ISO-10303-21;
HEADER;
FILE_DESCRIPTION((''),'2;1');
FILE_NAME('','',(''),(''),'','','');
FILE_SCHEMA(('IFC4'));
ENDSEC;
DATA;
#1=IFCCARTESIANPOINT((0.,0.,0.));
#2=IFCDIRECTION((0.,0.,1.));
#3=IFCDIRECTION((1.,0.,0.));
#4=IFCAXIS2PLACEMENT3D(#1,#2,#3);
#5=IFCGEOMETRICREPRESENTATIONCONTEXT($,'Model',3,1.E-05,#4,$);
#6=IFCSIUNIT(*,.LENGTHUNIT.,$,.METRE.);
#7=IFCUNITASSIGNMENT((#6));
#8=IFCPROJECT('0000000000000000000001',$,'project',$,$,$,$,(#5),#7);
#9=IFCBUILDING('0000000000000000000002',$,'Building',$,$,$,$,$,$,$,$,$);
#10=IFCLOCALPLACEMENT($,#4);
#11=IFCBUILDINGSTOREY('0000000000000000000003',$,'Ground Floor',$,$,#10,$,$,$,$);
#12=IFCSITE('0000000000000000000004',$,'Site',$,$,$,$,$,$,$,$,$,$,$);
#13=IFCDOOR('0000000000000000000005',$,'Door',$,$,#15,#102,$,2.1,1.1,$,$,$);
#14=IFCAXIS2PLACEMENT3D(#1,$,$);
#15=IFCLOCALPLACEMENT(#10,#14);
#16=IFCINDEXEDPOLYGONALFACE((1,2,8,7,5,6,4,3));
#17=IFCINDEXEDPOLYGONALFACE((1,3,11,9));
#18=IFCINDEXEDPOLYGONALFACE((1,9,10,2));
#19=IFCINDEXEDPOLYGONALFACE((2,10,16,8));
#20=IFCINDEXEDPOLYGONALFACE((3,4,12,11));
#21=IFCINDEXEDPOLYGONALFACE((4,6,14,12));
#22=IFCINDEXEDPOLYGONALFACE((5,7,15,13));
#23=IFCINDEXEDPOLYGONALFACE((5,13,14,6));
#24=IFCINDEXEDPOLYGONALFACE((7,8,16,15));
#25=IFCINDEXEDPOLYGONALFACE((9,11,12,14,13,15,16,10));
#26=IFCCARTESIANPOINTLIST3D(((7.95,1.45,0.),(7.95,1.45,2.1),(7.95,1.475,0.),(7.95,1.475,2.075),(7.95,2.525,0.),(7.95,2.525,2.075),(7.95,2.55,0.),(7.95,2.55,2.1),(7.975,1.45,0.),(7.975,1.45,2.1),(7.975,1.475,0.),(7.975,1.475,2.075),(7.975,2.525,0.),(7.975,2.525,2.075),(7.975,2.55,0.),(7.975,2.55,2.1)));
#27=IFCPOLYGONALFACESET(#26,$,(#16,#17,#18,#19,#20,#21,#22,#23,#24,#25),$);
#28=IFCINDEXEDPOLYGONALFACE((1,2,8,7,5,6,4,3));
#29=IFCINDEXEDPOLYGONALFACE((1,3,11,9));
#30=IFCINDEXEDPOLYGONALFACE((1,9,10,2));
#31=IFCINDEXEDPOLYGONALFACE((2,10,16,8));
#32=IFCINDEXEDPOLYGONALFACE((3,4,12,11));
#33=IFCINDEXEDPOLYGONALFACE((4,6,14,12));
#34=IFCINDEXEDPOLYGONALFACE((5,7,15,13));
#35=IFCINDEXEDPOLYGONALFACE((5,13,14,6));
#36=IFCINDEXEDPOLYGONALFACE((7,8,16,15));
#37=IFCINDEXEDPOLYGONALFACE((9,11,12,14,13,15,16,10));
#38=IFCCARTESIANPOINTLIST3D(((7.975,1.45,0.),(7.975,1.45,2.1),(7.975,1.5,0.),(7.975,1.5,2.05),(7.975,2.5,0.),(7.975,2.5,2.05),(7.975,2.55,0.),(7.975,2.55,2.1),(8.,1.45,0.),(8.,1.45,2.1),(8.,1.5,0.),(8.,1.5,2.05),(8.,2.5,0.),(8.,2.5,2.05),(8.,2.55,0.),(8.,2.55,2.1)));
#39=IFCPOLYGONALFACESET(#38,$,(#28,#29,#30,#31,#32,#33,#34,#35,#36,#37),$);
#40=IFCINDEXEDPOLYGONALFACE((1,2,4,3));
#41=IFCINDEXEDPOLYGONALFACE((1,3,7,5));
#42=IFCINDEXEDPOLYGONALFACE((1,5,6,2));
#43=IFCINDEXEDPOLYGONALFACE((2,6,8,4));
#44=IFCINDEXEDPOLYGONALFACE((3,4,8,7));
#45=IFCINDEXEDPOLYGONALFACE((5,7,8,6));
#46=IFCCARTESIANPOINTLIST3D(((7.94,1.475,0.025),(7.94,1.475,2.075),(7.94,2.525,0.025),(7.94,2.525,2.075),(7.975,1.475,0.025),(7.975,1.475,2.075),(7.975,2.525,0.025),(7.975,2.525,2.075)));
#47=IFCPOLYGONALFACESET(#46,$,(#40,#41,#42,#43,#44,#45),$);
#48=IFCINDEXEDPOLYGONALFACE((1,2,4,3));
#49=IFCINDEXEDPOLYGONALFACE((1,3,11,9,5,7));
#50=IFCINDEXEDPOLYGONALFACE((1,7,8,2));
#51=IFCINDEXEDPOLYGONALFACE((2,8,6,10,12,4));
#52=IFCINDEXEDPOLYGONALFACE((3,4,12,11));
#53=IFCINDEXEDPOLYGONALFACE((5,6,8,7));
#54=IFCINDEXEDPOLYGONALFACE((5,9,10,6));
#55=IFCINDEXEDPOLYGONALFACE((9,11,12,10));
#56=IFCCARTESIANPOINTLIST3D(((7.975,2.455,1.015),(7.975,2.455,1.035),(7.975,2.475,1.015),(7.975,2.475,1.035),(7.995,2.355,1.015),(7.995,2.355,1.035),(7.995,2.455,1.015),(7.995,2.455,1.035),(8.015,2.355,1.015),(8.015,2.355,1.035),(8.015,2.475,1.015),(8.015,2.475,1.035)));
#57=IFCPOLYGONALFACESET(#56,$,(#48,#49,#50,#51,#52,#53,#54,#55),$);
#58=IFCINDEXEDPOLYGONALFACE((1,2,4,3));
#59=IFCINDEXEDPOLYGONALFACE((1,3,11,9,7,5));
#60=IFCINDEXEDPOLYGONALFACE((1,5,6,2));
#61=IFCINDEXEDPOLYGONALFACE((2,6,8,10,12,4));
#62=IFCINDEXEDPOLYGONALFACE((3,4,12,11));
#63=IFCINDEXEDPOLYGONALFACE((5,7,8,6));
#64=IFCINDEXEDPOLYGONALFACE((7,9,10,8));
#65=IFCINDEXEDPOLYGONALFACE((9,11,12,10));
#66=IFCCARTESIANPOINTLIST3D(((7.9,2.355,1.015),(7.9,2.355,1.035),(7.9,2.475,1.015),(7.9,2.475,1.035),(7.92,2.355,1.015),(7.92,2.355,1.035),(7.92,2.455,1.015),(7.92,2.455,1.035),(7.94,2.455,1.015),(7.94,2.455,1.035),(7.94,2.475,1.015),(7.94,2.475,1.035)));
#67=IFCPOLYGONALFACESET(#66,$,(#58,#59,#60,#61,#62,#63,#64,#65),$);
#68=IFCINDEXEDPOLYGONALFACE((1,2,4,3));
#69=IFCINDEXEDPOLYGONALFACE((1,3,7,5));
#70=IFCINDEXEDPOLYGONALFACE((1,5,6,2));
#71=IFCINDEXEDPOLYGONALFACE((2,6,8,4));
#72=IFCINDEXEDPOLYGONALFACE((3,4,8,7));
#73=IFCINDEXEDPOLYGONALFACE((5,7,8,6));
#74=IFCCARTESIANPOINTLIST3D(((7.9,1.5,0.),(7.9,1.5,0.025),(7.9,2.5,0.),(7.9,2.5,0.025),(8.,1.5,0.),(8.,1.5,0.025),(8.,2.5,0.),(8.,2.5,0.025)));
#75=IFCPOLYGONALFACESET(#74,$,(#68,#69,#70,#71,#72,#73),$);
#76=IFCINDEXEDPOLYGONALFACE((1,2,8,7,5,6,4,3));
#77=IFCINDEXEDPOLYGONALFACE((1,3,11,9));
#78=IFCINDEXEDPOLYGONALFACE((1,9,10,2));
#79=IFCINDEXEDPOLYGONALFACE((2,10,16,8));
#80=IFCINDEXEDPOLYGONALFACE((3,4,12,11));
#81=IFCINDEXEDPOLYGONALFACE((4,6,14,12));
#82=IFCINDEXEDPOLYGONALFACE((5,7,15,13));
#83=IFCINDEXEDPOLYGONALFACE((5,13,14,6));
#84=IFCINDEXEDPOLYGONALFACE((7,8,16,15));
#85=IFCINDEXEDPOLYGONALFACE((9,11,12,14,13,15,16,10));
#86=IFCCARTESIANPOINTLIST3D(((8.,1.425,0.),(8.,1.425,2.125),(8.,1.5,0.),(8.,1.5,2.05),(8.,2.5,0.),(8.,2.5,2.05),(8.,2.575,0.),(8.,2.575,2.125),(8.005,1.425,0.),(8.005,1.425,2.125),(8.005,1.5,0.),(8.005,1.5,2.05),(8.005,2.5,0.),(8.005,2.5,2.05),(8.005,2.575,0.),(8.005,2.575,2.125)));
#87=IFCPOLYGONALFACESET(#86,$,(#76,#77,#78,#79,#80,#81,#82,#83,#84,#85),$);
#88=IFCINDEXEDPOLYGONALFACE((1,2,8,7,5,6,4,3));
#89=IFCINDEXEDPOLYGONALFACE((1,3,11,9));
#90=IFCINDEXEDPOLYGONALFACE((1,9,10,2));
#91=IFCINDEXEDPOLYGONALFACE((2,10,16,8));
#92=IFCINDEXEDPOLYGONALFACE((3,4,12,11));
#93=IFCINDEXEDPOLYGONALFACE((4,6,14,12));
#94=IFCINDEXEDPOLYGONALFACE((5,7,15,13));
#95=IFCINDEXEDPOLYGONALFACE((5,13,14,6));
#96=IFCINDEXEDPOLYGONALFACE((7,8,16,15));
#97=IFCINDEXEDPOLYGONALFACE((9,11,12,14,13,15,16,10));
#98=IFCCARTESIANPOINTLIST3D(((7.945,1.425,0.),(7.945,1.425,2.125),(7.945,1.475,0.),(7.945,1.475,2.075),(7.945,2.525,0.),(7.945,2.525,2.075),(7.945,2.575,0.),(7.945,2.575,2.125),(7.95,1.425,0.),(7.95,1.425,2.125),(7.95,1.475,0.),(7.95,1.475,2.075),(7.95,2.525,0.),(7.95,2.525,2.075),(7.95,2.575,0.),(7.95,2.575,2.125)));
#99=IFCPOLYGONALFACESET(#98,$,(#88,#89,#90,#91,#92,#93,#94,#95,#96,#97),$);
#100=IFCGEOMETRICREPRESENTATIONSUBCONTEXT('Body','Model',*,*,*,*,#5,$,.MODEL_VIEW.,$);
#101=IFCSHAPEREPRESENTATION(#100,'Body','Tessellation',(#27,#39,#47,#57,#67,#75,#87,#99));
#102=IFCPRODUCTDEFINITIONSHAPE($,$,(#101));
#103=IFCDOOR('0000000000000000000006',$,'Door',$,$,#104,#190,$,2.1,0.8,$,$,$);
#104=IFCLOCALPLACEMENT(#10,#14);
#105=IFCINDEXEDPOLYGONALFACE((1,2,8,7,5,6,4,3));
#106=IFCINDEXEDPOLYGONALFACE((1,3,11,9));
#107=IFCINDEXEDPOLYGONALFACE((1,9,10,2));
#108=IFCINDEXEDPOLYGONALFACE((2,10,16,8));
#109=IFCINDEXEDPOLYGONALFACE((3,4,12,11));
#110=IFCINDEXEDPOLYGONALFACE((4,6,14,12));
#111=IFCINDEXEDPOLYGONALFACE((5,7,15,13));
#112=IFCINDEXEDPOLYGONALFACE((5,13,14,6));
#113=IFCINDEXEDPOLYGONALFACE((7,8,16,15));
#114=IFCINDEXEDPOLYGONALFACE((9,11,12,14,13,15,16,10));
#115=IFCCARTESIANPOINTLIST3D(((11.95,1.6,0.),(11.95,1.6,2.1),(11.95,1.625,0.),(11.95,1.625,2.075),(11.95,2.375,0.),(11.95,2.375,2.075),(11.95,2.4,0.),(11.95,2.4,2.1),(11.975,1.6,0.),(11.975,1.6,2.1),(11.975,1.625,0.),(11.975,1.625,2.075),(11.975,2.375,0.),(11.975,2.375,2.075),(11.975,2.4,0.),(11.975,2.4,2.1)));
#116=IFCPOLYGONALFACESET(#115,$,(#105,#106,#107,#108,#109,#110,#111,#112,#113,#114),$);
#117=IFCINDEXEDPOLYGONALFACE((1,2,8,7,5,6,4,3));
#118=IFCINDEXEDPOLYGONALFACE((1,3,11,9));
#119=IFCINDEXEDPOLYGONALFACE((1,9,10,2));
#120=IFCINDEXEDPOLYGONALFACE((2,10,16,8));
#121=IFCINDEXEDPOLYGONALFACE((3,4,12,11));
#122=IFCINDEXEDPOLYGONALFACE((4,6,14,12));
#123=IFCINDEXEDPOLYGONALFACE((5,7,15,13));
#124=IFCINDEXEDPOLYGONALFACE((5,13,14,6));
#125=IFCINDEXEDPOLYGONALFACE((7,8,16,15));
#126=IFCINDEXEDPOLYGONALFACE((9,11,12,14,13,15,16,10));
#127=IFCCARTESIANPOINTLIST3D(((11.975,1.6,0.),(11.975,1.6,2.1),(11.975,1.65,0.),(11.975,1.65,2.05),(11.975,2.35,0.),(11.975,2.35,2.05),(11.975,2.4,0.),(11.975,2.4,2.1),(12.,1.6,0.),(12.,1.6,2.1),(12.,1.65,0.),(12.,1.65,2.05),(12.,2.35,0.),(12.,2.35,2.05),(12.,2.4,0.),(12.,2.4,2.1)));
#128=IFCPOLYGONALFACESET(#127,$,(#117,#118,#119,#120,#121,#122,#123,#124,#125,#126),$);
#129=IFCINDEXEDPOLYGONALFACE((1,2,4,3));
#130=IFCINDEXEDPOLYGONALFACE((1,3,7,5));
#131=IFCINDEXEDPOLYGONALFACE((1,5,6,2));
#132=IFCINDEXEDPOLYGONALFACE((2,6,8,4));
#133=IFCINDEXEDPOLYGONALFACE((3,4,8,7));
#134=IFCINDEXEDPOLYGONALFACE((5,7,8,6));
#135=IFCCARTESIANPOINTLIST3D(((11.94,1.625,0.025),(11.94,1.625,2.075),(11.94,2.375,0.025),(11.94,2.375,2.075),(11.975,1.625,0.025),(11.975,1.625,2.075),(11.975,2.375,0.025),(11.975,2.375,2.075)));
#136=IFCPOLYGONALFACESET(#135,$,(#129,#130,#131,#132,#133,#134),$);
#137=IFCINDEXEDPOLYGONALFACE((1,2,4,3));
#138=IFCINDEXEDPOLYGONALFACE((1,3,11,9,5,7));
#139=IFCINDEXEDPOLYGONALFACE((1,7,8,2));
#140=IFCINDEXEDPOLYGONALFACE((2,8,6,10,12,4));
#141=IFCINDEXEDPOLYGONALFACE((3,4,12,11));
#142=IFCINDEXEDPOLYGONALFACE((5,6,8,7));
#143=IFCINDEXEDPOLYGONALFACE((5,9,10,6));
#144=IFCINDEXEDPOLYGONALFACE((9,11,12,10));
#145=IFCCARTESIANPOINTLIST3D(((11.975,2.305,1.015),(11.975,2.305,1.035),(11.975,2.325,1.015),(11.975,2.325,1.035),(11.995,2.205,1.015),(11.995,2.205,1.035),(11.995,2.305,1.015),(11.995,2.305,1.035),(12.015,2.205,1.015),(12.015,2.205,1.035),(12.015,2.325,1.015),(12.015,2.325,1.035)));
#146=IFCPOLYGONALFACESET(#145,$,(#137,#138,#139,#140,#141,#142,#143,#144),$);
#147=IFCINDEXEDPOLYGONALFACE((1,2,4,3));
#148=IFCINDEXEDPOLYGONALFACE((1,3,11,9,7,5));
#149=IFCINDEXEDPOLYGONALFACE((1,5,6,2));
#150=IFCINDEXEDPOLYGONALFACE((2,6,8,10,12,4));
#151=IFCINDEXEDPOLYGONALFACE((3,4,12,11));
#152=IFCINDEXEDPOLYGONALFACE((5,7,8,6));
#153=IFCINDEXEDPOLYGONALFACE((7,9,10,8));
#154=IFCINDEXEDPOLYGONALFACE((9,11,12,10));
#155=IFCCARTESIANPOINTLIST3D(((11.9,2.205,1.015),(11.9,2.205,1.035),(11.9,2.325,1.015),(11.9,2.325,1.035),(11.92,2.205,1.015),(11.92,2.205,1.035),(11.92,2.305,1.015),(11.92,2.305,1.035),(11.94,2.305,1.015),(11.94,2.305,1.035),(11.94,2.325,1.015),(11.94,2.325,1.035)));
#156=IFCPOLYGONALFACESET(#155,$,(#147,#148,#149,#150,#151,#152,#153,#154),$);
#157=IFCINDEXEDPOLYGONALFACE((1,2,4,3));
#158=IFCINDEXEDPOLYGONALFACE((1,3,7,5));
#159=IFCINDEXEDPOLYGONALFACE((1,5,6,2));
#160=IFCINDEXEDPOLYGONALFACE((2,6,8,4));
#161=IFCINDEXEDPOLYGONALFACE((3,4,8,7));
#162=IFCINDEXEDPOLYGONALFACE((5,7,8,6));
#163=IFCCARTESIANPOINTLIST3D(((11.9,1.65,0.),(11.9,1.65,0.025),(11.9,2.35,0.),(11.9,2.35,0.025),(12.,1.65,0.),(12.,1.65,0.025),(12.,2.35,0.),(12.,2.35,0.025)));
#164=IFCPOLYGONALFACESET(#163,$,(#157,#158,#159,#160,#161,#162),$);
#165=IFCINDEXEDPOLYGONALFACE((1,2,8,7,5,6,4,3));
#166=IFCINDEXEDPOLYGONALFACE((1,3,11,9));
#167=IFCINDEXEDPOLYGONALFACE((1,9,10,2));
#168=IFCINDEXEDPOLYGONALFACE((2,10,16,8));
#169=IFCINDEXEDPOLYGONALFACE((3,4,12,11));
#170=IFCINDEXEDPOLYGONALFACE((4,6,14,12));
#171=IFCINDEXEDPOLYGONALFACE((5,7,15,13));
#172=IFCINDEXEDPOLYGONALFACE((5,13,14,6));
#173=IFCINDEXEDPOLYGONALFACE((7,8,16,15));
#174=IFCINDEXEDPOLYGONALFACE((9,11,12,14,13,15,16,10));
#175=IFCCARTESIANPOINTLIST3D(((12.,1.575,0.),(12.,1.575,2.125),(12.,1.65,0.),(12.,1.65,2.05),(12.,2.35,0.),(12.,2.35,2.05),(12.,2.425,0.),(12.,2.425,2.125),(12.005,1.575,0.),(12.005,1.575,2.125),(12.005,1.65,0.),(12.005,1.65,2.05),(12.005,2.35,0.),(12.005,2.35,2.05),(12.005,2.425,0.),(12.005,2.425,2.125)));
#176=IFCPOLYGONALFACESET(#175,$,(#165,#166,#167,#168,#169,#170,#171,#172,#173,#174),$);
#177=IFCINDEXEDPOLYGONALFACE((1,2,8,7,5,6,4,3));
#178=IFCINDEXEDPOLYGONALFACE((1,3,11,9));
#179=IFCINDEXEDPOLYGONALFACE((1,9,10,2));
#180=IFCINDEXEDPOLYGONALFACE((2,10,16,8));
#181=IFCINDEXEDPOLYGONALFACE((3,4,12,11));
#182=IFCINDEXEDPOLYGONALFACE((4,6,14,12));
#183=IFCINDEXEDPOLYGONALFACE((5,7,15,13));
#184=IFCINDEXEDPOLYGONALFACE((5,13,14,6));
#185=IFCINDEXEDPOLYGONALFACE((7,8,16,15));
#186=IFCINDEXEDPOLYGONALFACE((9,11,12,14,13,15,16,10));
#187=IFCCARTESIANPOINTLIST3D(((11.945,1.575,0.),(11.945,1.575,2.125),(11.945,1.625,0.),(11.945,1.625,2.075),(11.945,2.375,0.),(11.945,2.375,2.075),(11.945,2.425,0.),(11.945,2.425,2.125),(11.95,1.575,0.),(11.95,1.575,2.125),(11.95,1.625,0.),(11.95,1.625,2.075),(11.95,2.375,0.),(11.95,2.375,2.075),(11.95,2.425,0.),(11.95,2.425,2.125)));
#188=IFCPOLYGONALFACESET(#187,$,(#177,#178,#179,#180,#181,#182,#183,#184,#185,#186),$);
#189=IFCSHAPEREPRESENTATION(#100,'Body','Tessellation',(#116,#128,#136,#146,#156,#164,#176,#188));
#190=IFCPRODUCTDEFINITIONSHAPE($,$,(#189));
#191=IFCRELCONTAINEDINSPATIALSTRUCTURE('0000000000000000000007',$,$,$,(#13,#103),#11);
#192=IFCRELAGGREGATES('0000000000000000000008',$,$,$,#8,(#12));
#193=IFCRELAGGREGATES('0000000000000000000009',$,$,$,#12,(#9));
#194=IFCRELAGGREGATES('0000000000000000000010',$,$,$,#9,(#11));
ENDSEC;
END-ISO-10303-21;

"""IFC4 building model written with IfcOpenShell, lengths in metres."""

from ifc_helpers import new_model, si_unit, frame, origin_with_axes, place, context, subcontext, project, spatial, line, indexed_curve, outline, extrude, element, save


model = new_model("IFC4")

# Units and contexts
model_context = context("Model", 3, precision=1e-05, world=origin_with_axes())
body_context = subcontext(model_context, "Body", "Model", "MODEL_VIEW")
ifc_project = project(units=[si_unit("LENGTHUNIT", "METRE")], contexts=[model_context])

# Site, building, storey
site = spatial("IfcSite", under=ifc_project, Name="Site")
building = spatial("IfcBuilding", under=site, Name="Building")
storey_placement = place(None, origin_with_axes())
storey = spatial("IfcBuildingStorey", under=building, at=storey_placement, Name="Ground Floor")

# Doors
door_1_placement = place(storey_placement, frame((8.0, 1.45, 0.0), z_axis=(0.0, 0.0, 1.0), x_axis=(0.0, 1.0, 0.0)))
element("IfcDoor", 1, at=door_1_placement, inside=storey, Name="Door", OverallHeight=2.1, OverallWidth=1.1, context=body_context, shape_type="SweptSolid", body=[
    extrude(outline(indexed_curve([(0.0, 0.0), (0.0, 2.1), (1.1, 2.1), (1.1, 0.0), (1.075, 0.0), (1.075, 2.075), (0.025, 2.075), (0.025, 0.0)], segments=[line(1, 2, 3, 4, 5, 6, 7, 8, 1)])), frame((0.0, 0.025, 0.0), z_axis=(0.0, -1.0, 0.0), x_axis=(1.0, 0.0, 0.0)), (0.0, 0.0, -1.0), 0.025),
    extrude(outline(indexed_curve([(0.0, 0.0), (0.0, 2.1), (1.1, 2.1), (1.1, 0.0), (1.05, 0.0), (1.05, 2.05), (0.05, 2.05), (0.05, 0.0)], segments=[line(1, 2, 3, 4, 5, 6, 7, 8, 1)])), frame((0.0, 0.0, 0.0), z_axis=(0.0, -1.0, 0.0), x_axis=(1.0, 0.0, 0.0)), (0.0, 0.0, -1.0), 0.025),
    extrude(outline(indexed_curve([(0.0, 0.0), (1.05, 0.0), (1.05, 0.035), (0.0, 0.035)], segments=[line(1, 2, 3, 4, 1)])), frame((0.025, 0.025, 0.025), z_axis=(0.0, 0.0, 1.0), x_axis=(1.0, 0.0, 0.0)), (0.0, 0.0, 1.0), 2.05),
    extrude(outline(indexed_curve([(0.0, 0.0), (0.0, -0.04), (-0.12, -0.04), (-0.12, -0.02), (-0.02, -0.02), (-0.02, 0.0)], segments=[line(1, 2, 3, 4, 5, 6, 1)])), frame((1.025, 0.025, 1.015), z_axis=(0.0, 0.0, 1.0), x_axis=(1.0, 0.0, 0.0)), (0.0, 0.0, 1.0), 0.02),
    extrude(outline(indexed_curve([(0.0, 0.0), (0.0, 0.04), (-0.12, 0.04), (-0.12, 0.02), (-0.02, 0.02), (-0.02, 0.0)], segments=[line(1, 2, 3, 4, 5, 6, 1)])), frame((1.025, 0.06, 1.015), z_axis=(0.0, 0.0, 1.0), x_axis=(1.0, 0.0, 0.0)), (0.0, 0.0, 1.0), 0.02),
    extrude(outline(indexed_curve([(0.0, 0.0), (1.0, 0.0), (1.0, 0.1), (0.0, 0.1)], segments=[line(1, 2, 3, 4, 1)])), frame((0.05, 0.0, 0.0), z_axis=(0.0, 0.0, 1.0), x_axis=(1.0, 0.0, 0.0)), (0.0, 0.0, 1.0), 0.025),
    extrude(outline(indexed_curve([(0.0, 0.0), (0.0, 2.125), (1.15, 2.125), (1.15, 0.0), (1.075, 0.0), (1.075, 2.05), (0.075, 2.05), (0.075, 0.0)], segments=[line(1, 2, 3, 4, 5, 6, 7, 8, 1)])), frame((-0.025, -0.005, 0.0), z_axis=(0.0, -1.0, 0.0), x_axis=(1.0, 0.0, 0.0)), (0.0, 0.0, -1.0), 0.005),
    extrude(outline(indexed_curve([(0.0, 0.0), (0.0, 2.125), (1.15, 2.125), (1.15, 0.0), (1.1, 0.0), (1.1, 2.075), (0.05, 2.075), (0.05, 0.0)], segments=[line(1, 2, 3, 4, 5, 6, 7, 8, 1)])), frame((-0.025, 0.05, 0.0), z_axis=(0.0, -1.0, 0.0), x_axis=(1.0, 0.0, 0.0)), (0.0, 0.0, -1.0), 0.005),
])
door_2_placement = place(storey_placement, frame((12.0, 1.6, 0.0), z_axis=(0.0, 0.0, 1.0), x_axis=(0.0, 1.0, 0.0)))
element("IfcDoor", 2, at=door_2_placement, inside=storey, Name="Door", OverallHeight=2.1, OverallWidth=0.8, context=body_context, shape_type="SweptSolid", body=[
    extrude(outline(indexed_curve([(0.0, 0.0), (0.0, 2.1), (0.8, 2.1), (0.8, 0.0), (0.775, 0.0), (0.775, 2.075), (0.025, 2.075), (0.025, 0.0)], segments=[line(1, 2, 3, 4, 5, 6, 7, 8, 1)])), frame((0.0, 0.025, 0.0), z_axis=(0.0, -1.0, 0.0), x_axis=(1.0, 0.0, 0.0)), (0.0, 0.0, -1.0), 0.025),
    extrude(outline(indexed_curve([(0.0, 0.0), (0.0, 2.1), (0.8, 2.1), (0.8, 0.0), (0.75, 0.0), (0.75, 2.05), (0.05, 2.05), (0.05, 0.0)], segments=[line(1, 2, 3, 4, 5, 6, 7, 8, 1)])), frame((0.0, 0.0, 0.0), z_axis=(0.0, -1.0, 0.0), x_axis=(1.0, 0.0, 0.0)), (0.0, 0.0, -1.0), 0.025),
    extrude(outline(indexed_curve([(0.0, 0.0), (0.75, 0.0), (0.75, 0.035), (0.0, 0.035)], segments=[line(1, 2, 3, 4, 1)])), frame((0.025, 0.025, 0.025), z_axis=(0.0, 0.0, 1.0), x_axis=(1.0, 0.0, 0.0)), (0.0, 0.0, 1.0), 2.05),
    extrude(outline(indexed_curve([(0.0, 0.0), (0.0, -0.04), (-0.12, -0.04), (-0.12, -0.02), (-0.02, -0.02), (-0.02, 0.0)], segments=[line(1, 2, 3, 4, 5, 6, 1)])), frame((0.725, 0.025, 1.015), z_axis=(0.0, 0.0, 1.0), x_axis=(1.0, 0.0, 0.0)), (0.0, 0.0, 1.0), 0.02),
    extrude(outline(indexed_curve([(0.0, 0.0), (0.0, 0.04), (-0.12, 0.04), (-0.12, 0.02), (-0.02, 0.02), (-0.02, 0.0)], segments=[line(1, 2, 3, 4, 5, 6, 1)])), frame((0.725, 0.06, 1.015), z_axis=(0.0, 0.0, 1.0), x_axis=(1.0, 0.0, 0.0)), (0.0, 0.0, 1.0), 0.02),
    extrude(outline(indexed_curve([(0.0, 0.0), (0.7, 0.0), (0.7, 0.1), (0.0, 0.1)], segments=[line(1, 2, 3, 4, 1)])), frame((0.05, 0.0, 0.0), z_axis=(0.0, 0.0, 1.0), x_axis=(1.0, 0.0, 0.0)), (0.0, 0.0, 1.0), 0.025),
    extrude(outline(indexed_curve([(0.0, 0.0), (0.0, 2.125), (0.85, 2.125), (0.85, 0.0), (0.775, 0.0), (0.775, 2.05), (0.075, 2.05), (0.075, 0.0)], segments=[line(1, 2, 3, 4, 5, 6, 7, 8, 1)])), frame((-0.025, -0.005, 0.0), z_axis=(0.0, -1.0, 0.0), x_axis=(1.0, 0.0, 0.0)), (0.0, 0.0, -1.0), 0.005),
    extrude(outline(indexed_curve([(0.0, 0.0), (0.0, 2.125), (0.85, 2.125), (0.85, 0.0), (0.8, 0.0), (0.8, 2.075), (0.05, 2.075), (0.05, 0.0)], segments=[line(1, 2, 3, 4, 5, 6, 7, 8, 1)])), frame((-0.025, 0.05, 0.0), z_axis=(0.0, -1.0, 0.0), x_axis=(1.0, 0.0, 0.0)), (0.0, 0.0, -1.0), 0.005),
])

save(model, "model.ifc")
